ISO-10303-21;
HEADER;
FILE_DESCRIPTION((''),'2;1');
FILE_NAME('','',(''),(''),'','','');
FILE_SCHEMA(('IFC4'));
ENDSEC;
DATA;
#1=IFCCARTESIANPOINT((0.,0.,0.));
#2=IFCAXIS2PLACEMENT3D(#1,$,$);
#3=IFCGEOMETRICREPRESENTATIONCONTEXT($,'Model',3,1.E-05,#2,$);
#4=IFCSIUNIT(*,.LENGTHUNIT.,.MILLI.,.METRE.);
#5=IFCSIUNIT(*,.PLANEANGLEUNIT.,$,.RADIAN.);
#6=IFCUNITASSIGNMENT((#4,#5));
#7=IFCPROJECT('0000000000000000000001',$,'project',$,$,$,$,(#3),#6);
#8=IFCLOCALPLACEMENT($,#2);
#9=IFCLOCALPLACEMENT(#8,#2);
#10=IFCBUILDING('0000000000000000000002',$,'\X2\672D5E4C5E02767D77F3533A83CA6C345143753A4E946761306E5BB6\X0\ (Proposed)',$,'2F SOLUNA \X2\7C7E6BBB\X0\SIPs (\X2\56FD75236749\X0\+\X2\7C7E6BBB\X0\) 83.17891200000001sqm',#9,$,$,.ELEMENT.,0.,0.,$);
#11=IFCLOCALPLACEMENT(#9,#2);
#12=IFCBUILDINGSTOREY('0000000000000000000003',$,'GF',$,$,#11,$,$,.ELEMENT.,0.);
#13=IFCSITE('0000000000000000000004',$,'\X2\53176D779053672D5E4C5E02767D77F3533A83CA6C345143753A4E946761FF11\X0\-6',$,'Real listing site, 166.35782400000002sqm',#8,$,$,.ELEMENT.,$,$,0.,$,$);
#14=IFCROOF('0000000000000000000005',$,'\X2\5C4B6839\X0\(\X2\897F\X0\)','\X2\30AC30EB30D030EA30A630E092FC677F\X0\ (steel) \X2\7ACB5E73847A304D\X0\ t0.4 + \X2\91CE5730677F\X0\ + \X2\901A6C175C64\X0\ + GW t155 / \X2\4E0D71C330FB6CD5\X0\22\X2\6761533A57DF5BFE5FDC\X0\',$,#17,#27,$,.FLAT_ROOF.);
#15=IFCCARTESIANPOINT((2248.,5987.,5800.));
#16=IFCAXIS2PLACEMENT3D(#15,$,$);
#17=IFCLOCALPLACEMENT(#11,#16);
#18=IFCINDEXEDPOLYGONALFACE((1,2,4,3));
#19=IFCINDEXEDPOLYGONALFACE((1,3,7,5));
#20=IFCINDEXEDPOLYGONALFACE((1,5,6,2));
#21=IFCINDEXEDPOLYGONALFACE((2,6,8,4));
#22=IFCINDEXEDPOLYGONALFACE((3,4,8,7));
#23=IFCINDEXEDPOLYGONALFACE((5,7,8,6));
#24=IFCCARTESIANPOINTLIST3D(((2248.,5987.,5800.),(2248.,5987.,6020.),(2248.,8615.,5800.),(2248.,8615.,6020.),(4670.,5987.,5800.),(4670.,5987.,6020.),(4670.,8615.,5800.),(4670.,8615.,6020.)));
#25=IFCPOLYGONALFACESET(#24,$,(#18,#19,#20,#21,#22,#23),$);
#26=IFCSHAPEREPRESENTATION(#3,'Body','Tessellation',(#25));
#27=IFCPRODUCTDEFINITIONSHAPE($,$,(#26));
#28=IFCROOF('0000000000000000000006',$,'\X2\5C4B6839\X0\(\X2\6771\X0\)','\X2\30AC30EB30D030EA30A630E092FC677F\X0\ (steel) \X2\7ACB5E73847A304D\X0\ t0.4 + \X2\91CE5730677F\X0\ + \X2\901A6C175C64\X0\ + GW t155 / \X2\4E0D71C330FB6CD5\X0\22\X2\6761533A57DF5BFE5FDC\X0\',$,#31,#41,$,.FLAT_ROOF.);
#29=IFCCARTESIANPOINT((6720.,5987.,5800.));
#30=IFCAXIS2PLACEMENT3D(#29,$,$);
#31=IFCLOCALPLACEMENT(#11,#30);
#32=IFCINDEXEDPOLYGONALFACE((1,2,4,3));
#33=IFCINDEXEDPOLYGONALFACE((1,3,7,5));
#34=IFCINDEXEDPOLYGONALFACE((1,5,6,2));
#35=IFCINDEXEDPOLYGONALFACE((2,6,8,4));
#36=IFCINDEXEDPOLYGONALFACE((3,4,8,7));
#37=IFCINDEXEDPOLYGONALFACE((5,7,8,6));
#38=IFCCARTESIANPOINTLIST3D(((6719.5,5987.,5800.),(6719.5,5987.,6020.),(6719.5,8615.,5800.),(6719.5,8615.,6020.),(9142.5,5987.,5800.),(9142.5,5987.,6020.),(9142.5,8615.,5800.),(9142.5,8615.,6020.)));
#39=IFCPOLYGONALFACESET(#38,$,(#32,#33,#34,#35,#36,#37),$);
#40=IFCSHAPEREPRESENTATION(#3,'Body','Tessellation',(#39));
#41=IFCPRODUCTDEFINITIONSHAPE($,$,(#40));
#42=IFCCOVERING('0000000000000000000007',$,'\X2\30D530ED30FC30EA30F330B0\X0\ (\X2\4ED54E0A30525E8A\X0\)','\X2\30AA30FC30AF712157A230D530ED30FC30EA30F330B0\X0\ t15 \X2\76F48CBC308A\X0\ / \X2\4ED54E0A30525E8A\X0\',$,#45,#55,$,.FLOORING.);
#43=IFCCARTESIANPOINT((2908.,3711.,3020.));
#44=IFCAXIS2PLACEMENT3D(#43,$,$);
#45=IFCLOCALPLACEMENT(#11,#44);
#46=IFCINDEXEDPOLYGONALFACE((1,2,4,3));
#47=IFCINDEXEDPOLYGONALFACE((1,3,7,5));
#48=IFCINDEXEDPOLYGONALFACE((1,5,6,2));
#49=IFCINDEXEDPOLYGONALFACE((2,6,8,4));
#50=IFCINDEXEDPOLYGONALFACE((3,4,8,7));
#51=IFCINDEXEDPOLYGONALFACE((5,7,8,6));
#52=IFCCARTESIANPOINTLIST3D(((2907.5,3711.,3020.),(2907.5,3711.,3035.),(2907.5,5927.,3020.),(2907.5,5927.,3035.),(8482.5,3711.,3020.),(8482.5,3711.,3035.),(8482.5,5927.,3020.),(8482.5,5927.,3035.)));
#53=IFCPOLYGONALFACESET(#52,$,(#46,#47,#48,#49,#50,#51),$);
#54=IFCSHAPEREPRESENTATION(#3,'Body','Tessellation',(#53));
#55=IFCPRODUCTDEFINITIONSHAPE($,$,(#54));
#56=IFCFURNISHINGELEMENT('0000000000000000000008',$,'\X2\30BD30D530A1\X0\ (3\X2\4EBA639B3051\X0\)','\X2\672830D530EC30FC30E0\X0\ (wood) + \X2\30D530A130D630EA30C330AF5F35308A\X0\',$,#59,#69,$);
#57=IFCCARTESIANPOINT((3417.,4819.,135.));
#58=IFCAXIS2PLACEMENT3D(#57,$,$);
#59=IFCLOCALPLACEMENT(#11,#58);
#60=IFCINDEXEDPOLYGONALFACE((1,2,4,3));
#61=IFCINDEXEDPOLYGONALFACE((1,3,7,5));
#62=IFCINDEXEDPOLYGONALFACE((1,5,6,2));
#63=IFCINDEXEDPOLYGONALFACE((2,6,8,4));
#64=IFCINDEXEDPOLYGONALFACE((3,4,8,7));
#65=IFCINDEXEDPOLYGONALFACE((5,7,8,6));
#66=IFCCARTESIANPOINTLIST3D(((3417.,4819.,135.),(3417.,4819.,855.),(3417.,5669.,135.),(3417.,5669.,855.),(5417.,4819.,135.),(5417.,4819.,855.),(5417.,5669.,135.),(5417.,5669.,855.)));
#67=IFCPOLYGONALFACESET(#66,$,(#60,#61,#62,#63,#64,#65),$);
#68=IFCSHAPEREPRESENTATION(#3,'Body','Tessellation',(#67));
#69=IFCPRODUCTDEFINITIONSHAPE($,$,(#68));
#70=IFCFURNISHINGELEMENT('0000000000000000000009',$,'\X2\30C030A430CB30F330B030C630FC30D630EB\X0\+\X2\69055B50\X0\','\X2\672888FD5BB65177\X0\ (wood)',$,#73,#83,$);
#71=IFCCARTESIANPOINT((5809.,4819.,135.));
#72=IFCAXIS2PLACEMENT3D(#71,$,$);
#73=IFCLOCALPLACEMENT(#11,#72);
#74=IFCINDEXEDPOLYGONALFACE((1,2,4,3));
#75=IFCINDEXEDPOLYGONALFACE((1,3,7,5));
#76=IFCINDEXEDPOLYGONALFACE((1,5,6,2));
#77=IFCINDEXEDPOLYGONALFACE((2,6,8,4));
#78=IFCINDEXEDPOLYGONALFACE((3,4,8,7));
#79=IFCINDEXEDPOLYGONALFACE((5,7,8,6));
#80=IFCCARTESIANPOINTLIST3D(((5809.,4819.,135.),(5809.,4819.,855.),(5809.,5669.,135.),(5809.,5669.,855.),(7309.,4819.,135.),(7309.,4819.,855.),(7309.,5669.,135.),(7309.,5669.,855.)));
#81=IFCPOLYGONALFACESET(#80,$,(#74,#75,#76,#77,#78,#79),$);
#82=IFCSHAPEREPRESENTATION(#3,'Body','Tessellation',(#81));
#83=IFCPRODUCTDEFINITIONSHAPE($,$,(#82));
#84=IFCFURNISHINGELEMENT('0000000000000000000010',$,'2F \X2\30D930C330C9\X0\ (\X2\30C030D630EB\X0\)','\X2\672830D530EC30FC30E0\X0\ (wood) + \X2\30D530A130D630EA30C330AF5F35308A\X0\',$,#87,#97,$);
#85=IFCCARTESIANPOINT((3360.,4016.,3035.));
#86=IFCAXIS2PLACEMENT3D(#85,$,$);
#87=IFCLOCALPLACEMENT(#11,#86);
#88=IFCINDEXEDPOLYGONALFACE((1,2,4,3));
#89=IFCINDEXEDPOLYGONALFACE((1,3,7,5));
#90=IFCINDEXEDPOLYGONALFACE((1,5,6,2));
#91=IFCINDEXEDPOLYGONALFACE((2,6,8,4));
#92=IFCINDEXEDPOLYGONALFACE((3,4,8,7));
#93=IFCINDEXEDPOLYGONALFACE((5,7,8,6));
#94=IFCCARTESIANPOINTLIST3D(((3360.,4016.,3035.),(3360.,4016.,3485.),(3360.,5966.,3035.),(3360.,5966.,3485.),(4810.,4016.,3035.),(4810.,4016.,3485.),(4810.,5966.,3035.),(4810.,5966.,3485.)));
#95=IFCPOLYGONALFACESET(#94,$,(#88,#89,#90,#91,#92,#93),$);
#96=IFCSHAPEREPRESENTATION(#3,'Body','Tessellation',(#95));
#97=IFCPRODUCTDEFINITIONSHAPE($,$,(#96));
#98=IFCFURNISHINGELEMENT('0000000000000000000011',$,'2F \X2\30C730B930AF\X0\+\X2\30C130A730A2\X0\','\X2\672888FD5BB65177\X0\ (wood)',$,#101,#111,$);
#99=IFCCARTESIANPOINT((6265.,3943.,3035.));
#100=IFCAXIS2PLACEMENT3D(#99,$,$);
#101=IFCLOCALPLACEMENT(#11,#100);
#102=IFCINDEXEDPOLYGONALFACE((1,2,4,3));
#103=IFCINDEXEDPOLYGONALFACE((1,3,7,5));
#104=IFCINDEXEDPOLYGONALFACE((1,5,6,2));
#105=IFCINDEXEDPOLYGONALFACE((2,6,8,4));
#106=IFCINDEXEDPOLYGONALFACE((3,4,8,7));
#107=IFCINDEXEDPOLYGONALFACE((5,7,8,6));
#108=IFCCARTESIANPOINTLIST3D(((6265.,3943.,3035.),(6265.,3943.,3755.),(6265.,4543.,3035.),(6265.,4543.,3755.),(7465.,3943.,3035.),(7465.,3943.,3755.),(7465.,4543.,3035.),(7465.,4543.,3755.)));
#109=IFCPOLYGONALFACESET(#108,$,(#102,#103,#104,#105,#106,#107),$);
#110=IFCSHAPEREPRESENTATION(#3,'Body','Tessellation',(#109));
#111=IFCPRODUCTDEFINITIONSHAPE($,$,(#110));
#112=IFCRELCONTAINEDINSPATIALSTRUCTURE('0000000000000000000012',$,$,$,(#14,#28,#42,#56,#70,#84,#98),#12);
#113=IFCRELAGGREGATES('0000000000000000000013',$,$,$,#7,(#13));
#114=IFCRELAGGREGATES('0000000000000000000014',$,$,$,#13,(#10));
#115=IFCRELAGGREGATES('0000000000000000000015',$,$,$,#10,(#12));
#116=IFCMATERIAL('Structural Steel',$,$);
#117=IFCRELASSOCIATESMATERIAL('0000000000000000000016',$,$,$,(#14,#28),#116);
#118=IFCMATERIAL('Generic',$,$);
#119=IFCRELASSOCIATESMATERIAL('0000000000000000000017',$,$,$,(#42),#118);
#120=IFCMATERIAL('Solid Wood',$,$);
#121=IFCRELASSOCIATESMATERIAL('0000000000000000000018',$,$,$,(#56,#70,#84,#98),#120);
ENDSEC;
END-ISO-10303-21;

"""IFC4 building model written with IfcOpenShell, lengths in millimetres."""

from ifc_helpers import new_model, si_unit, frame, frame_2d, origin, place, context, project, spatial, rectangle, extrude, material, element, save


model = new_model("IFC4")

# Units and contexts
model_context = context("Model", 3, precision=1e-05, world=origin())
ifc_project = project(units=[si_unit("LENGTHUNIT", "METRE", prefix="MILLI"), si_unit("PLANEANGLEUNIT", "RADIAN")], contexts=[model_context])

# Site, building, storey
site_placement = place(None, origin())
site = spatial("IfcSite", under=ifc_project, at=site_placement, Name="北海道札幌市白石区菊水元町五条１-6", ObjectType="Real listing site, 166.35782400000002sqm", CompositionType="ELEMENT", RefElevation=0.0)
building_placement = place(site_placement, origin())
building = spatial("IfcBuilding", under=site, at=building_placement, Name="札幌市白石区菊水元町五条の家 (Proposed)", ObjectType="2F SOLUNA 籾殻SIPs (国産杉+籾殻) 83.17891200000001sqm", CompositionType="ELEMENT", ElevationOfRefHeight=0.0, ElevationOfTerrain=0.0)
storey_placement = place(building_placement, origin())
storey = spatial("IfcBuildingStorey", under=building, at=storey_placement, Name="GF", CompositionType="ELEMENT", Elevation=0.0)

# Shared definitions
ifc_material_1 = material(Name="Solid Wood")

# Roofs
ifc_material_2 = material(Name="Structural Steel")
roof_1_placement = place(storey_placement, frame((2248.0, 5987.0, 5800.0)))
element("IfcRoof", 1, at=roof_1_placement, inside=storey, material=ifc_material_2, Name="屋根(西)", Description="ガルバリウム鋼板 (steel) 立平葺き t0.4 + 野地板 + 通気層 + GW t155 / 不燃・法22条区域対応", PredefinedType="FLAT_ROOF", context=model_context, shape_type="SweptSolid", body=[
    extrude(rectangle(XDim=2422.0, YDim=2628.0, at=frame_2d((1211.0, 1314.0))), frame((2248.0, 5987.0, 5800.0)), (0.0, 0.0, 1.0), 220.0),
])
roof_2_placement = place(storey_placement, frame((6720.0, 5987.0, 5800.0)))
element("IfcRoof", 2, at=roof_2_placement, inside=storey, material=ifc_material_2, Name="屋根(東)", Description="ガルバリウム鋼板 (steel) 立平葺き t0.4 + 野地板 + 通気層 + GW t155 / 不燃・法22条区域対応", PredefinedType="FLAT_ROOF", context=model_context, shape_type="SweptSolid", body=[
    extrude(rectangle(XDim=2423.0, YDim=2628.0, at=frame_2d((1211.0, 1314.0))), frame((6720.0, 5987.0, 5800.0)), (0.0, 0.0, 1.0), 220.0),
])

# Covering
ifc_material_3 = material(Name="Generic")
covering_placement = place(storey_placement, frame((2908.0, 3711.0, 3020.0)))
element("IfcCovering", 3, at=covering_placement, inside=storey, material=ifc_material_3, Name="フローリング (仕上げ床)", Description="オーク無垢フローリング t15 直貼り / 仕上げ床", PredefinedType="FLOORING", context=model_context, shape_type="SweptSolid", body=[
    extrude(rectangle(XDim=5575.0, YDim=2216.0, at=frame_2d((2787.0, 1108.0))), frame((2908.0, 3711.0, 3020.0)), (0.0, 0.0, 1.0), 15.0),
])

# Furnishing elements
furnishing_1_placement = place(storey_placement, frame((3417.0, 4819.0, 135.0)))
element("IfcFurnishingElement", 4, at=furnishing_1_placement, inside=storey, material=ifc_material_1, Name="ソファ (3人掛け)", Description="木フレーム (wood) + ファブリック張り", context=model_context, shape_type="SweptSolid", body=[
    extrude(rectangle(XDim=2000.0, YDim=850.0, at=frame_2d((1000.0, 425.0))), frame((3417.0, 4819.0, 135.0)), (0.0, 0.0, 1.0), 720.0),
])
furnishing_2_placement = place(storey_placement, frame((5809.0, 4819.0, 135.0)))
element("IfcFurnishingElement", 5, at=furnishing_2_placement, inside=storey, material=ifc_material_1, Name="ダイニングテーブル+椅子", Description="木製家具 (wood)", context=model_context, shape_type="SweptSolid", body=[
    extrude(rectangle(XDim=1500.0, YDim=850.0, at=frame_2d((750.0, 425.0))), frame((5809.0, 4819.0, 135.0)), (0.0, 0.0, 1.0), 720.0),
])
furnishing_3_placement = place(storey_placement, frame((3360.0, 4016.0, 3035.0)))
element("IfcFurnishingElement", 6, at=furnishing_3_placement, inside=storey, material=ifc_material_1, Name="2F ベッド (ダブル)", Description="木フレーム (wood) + ファブリック張り", context=model_context, shape_type="SweptSolid", body=[
    extrude(rectangle(XDim=1450.0, YDim=1950.0, at=frame_2d((725.0, 975.0))), frame((3360.0, 4016.0, 3035.0)), (0.0, 0.0, 1.0), 450.0),
])
furnishing_4_placement = place(storey_placement, frame((6265.0, 3943.0, 3035.0)))
element("IfcFurnishingElement", 7, at=furnishing_4_placement, inside=storey, material=ifc_material_1, Name="2F デスク+チェア", Description="木製家具 (wood)", context=model_context, shape_type="SweptSolid", body=[
    extrude(rectangle(XDim=1200.0, YDim=600.0, at=frame_2d((600.0, 300.0))), frame((6265.0, 3943.0, 3035.0)), (0.0, 0.0, 1.0), 720.0),
])

save(model, "model.ifc")
